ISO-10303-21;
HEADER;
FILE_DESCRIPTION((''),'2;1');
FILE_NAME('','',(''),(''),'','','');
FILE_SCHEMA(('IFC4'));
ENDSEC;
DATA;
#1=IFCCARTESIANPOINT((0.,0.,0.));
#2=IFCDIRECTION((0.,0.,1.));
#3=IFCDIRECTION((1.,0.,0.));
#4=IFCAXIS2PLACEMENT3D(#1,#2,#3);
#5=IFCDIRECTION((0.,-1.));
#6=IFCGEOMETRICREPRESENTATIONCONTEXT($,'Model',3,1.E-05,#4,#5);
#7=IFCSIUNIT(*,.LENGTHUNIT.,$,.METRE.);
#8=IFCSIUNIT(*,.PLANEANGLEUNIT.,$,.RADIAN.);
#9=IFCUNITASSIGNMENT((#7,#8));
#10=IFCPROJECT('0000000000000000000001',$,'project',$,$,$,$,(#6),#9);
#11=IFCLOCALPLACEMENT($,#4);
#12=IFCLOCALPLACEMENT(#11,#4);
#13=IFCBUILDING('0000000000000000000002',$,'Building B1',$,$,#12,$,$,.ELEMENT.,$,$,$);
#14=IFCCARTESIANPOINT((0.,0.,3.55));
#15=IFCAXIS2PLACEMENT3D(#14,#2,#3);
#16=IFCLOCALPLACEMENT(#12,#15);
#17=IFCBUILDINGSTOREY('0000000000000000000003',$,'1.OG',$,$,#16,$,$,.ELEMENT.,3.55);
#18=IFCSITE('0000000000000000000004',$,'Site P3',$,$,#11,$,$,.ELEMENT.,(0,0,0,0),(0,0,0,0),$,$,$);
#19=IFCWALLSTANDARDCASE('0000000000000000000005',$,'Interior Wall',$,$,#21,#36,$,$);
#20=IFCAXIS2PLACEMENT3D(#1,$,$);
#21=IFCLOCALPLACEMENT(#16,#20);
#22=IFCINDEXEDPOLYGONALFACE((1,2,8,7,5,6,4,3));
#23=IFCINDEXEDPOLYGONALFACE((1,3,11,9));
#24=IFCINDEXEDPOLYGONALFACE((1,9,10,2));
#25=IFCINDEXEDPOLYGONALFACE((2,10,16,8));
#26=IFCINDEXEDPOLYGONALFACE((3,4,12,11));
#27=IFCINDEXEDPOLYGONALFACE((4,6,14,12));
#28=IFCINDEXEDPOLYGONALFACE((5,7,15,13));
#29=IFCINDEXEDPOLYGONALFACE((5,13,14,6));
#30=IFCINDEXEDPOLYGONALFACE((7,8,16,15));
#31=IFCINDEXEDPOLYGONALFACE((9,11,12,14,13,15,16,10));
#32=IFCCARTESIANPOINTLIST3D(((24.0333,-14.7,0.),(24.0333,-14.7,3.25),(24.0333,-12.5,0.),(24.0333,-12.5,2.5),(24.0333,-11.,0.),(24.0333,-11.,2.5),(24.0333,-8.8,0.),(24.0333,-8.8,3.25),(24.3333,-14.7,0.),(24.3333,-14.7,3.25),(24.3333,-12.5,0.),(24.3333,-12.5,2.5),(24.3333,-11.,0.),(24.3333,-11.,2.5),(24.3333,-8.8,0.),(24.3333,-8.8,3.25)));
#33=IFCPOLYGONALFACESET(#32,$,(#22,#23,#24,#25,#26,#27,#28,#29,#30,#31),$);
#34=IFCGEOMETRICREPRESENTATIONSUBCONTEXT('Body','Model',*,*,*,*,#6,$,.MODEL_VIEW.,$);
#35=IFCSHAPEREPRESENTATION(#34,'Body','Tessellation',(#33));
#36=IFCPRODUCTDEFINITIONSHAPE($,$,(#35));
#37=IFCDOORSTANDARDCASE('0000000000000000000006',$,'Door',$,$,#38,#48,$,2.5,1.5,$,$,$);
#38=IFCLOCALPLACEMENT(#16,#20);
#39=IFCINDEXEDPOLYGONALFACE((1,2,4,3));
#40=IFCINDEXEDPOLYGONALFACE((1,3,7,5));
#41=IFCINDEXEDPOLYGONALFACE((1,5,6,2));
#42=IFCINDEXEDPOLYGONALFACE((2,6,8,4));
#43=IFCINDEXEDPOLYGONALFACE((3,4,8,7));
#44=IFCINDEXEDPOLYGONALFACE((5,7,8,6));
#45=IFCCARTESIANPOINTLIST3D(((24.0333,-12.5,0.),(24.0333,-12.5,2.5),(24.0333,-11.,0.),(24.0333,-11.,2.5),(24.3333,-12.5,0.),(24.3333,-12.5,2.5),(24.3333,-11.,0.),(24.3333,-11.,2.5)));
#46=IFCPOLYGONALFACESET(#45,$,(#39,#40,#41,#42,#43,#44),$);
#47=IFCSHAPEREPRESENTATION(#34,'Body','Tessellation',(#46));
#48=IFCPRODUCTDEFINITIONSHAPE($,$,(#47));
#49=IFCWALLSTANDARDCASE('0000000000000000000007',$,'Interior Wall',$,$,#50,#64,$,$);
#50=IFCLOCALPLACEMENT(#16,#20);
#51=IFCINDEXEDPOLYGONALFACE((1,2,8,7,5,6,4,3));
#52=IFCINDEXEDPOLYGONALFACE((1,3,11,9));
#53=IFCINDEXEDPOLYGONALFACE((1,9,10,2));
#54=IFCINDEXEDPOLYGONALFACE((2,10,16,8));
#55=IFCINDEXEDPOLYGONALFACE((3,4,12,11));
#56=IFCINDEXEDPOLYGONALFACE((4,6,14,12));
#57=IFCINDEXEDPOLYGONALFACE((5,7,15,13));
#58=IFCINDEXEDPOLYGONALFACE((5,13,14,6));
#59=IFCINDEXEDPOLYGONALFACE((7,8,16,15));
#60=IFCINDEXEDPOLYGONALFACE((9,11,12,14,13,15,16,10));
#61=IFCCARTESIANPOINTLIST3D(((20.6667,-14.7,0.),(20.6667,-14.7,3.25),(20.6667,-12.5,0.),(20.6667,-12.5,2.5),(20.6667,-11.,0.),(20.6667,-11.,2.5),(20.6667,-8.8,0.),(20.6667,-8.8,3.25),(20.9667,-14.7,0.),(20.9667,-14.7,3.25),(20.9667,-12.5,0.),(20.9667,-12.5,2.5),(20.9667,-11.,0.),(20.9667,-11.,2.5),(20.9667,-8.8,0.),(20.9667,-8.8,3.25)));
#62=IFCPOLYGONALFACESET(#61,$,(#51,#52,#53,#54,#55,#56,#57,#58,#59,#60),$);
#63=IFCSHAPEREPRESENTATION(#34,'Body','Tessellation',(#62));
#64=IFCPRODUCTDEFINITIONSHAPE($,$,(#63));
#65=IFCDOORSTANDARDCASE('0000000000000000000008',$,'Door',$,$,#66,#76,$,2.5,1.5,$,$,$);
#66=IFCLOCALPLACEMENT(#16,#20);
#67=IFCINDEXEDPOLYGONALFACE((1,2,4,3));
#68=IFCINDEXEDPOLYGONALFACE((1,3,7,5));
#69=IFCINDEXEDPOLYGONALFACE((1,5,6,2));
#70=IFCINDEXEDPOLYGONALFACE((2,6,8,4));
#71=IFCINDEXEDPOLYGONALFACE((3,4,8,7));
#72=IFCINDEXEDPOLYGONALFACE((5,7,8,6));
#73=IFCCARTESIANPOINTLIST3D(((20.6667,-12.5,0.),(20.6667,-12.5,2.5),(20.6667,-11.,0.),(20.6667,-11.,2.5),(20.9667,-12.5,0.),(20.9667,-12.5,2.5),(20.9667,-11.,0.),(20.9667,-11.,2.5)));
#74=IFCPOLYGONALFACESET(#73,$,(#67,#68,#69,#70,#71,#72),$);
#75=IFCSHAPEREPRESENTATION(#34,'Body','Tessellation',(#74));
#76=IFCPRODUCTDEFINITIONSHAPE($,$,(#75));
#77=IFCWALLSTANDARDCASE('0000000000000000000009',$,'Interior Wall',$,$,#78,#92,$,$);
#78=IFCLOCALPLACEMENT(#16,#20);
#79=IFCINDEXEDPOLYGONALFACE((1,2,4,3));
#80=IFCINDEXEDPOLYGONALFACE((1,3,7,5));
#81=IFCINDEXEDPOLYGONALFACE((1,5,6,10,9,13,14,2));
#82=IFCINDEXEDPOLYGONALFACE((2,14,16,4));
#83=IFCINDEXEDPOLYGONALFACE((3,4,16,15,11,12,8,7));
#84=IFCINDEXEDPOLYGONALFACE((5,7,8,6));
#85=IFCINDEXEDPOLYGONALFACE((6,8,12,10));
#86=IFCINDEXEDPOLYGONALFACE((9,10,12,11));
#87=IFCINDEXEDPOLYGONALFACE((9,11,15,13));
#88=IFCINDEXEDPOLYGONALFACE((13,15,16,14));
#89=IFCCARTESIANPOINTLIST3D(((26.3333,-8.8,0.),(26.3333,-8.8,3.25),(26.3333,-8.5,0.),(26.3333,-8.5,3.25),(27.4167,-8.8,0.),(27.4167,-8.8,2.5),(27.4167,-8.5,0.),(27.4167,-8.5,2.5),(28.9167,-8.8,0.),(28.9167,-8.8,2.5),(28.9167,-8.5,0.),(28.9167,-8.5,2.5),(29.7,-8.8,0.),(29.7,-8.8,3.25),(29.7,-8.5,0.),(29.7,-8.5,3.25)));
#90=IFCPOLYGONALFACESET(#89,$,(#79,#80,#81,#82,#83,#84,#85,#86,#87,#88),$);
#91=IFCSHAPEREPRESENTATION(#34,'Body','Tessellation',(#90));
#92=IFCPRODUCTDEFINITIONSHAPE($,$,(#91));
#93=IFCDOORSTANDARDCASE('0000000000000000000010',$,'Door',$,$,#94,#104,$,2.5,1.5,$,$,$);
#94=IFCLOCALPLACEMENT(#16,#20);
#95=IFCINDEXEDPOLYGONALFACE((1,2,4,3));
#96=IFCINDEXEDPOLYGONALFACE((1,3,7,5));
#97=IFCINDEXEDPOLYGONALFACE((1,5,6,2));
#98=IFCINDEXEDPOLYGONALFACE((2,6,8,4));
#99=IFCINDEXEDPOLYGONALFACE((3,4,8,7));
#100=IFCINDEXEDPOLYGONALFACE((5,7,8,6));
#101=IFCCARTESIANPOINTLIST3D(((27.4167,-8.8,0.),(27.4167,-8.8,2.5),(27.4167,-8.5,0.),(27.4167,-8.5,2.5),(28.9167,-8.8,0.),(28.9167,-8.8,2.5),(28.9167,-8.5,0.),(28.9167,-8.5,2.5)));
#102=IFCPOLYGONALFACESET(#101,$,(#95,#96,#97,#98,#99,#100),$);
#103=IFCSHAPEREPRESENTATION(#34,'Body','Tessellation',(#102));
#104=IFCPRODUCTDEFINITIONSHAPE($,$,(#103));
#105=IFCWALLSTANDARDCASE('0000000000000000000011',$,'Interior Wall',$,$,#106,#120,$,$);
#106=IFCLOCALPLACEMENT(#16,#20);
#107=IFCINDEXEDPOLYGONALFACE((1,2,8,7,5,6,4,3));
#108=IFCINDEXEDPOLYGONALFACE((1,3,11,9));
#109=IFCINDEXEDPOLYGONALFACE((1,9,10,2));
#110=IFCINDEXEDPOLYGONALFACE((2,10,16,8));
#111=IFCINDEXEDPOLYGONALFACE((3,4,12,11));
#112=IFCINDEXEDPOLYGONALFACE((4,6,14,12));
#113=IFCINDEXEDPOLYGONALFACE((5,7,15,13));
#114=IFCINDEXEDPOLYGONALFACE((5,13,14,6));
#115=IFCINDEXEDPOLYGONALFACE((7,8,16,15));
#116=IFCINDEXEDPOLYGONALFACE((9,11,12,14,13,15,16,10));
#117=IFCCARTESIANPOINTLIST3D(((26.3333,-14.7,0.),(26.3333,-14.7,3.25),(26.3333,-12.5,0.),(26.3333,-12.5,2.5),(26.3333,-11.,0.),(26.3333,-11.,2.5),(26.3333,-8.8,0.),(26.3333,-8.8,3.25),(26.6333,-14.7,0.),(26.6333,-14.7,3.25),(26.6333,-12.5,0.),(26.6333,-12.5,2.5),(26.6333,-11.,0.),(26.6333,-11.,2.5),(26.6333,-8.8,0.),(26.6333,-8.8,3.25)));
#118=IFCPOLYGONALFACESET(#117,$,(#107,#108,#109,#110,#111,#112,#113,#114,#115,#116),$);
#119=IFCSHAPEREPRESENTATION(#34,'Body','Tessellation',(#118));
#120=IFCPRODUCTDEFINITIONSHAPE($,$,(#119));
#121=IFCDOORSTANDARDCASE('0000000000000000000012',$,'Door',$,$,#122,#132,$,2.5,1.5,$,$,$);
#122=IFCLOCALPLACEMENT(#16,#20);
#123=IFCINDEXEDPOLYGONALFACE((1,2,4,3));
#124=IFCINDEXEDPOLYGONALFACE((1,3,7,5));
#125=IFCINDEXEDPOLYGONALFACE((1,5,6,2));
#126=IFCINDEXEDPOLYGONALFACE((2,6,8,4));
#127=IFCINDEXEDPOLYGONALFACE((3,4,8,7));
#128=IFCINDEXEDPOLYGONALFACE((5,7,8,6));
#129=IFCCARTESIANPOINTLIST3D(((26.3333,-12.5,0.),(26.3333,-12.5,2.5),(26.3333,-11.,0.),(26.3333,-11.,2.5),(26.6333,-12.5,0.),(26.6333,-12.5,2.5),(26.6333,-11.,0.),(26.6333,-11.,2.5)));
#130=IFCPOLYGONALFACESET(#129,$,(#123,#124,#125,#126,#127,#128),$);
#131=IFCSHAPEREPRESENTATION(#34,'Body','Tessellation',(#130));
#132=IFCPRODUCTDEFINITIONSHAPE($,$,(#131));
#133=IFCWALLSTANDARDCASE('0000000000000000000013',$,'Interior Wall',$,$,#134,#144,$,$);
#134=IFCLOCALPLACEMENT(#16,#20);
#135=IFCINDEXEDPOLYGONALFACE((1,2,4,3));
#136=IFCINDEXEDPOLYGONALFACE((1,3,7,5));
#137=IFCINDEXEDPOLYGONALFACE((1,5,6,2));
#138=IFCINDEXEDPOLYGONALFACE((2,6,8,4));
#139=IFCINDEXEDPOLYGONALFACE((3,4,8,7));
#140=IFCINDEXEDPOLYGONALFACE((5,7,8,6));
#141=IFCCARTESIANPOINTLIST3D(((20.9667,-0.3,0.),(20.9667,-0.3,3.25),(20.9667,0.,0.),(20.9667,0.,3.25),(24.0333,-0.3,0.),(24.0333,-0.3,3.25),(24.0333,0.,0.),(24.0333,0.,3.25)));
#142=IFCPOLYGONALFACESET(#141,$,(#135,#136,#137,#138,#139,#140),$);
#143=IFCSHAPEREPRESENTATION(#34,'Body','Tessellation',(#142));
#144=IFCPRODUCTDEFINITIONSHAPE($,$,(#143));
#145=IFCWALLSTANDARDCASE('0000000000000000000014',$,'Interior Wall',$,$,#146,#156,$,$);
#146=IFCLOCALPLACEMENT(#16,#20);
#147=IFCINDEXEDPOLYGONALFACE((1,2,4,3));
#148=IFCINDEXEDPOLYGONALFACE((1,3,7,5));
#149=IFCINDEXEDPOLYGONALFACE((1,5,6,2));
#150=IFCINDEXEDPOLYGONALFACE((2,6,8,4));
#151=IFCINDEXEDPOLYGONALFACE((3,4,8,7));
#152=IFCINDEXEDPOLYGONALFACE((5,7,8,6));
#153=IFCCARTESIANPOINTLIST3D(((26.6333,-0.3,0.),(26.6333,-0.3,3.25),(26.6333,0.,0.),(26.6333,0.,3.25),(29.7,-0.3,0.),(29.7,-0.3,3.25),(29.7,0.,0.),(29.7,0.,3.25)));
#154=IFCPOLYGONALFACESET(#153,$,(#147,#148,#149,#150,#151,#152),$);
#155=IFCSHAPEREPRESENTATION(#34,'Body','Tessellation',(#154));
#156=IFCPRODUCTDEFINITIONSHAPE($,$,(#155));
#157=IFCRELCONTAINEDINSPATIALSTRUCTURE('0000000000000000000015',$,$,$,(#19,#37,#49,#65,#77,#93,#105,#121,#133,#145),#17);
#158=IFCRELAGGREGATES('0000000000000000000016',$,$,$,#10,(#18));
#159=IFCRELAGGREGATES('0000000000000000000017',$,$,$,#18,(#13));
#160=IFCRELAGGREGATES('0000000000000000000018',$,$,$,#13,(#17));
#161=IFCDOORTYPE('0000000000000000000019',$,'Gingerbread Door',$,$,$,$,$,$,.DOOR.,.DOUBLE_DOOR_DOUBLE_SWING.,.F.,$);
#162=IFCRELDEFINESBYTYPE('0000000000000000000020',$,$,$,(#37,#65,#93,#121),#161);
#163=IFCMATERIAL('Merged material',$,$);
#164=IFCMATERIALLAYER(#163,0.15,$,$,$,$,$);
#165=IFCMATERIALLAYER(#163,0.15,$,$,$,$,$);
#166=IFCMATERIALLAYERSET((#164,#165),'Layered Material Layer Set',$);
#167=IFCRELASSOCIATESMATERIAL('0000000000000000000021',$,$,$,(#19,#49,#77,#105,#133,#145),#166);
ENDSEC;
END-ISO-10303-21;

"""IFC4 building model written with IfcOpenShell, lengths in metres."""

from ifc_helpers import new_model, si_unit, direction, frame, origin_with_axes, place, context, subcontext, project, spatial, polyline, outline, extrude, source, transform, mapped, material, layer, layer_set, layer_usage, type_object, element, fill, save


model = new_model("IFC4")

# Units and contexts
model_context = context("Model", 3, precision=1e-05, world=origin_with_axes(), true_north=direction((0.0, -1.0)))
body_context = subcontext(model_context, "Body", "Model", "MODEL_VIEW")
ifc_project = project(units=[si_unit("LENGTHUNIT", "METRE"), si_unit("PLANEANGLEUNIT", "RADIAN")], contexts=[model_context])

# Site, building, storey
site_placement = place(None, origin_with_axes())
site = spatial("IfcSite", under=ifc_project, at=site_placement, Name="Site P3", CompositionType="ELEMENT", RefLatitude=(0, 0, 0, 0), RefLongitude=(0, 0, 0, 0))
building_placement = place(site_placement, origin_with_axes())
building = spatial("IfcBuilding", under=site, at=building_placement, Name="Building B1", CompositionType="ELEMENT")
storey_placement = place(building_placement, frame((0.0, 0.0, 3.55), z_axis=(0.0, 0.0, 1.0), x_axis=(1.0, 0.0, 0.0)))
storey = spatial("IfcBuildingStorey", under=building, at=storey_placement, Name="1.OG", CompositionType="ELEMENT", Elevation=3.55)

# Shared definitions
ifc_material = material(Name="Merged material")

# Walls, openings, doors
ifc_layer_1 = layer(ifc_material, 0.15)
ifc_layer_2 = layer(ifc_material, 0.15)
ifc_layer_set_1 = layer_set([ifc_layer_1, ifc_layer_2], Name="Layered Material Layer Set")
ifc_layer_usage_1 = layer_usage(ifc_layer_set_1, "AXIS2", "POSITIVE", -0.15)
door_type = type_object("IfcDoorType", Name="Gingerbread Door", OperationType="DOUBLE_DOOR_DOUBLE_SWING", ParameterTakesPrecedence=False, PredefinedType="DOOR")
shared_shape_1 = source(origin_with_axes(), body_context, "Body", "SweptSolid", [
    extrude(outline(polyline([(0.0, 0.0), (0.0, 1.5), (2.5, 1.5), (2.5, 0.0), (0.0, 0.0)])), frame((0.0, -0.15, 0.0), z_axis=(0.0, 1.0, 0.0), x_axis=(0.0, 0.0, 1.0)), (0.0, 0.0, 1.0), 0.3),
])
wall_1_placement = place(storey_placement, frame((24.1833, -8.8, 0.0), z_axis=(0.0, 0.0, 1.0), x_axis=(0.0, -1.0, 0.0)))
wall_1 = element("IfcWallStandardCase", 1, at=wall_1_placement, inside=storey, material=ifc_layer_usage_1, Name="Interior Wall", context=body_context, shape_type="SweptSolid", body=[
    extrude(outline(polyline([(0.0, 0.15), (5.9, 0.15), (5.9, -0.15), (0.0, -0.15), (0.0, 0.15)])), origin_with_axes(), (0.0, 0.0, 1.0), 3.25),
])
opening_1_placement = place(wall_1_placement, frame((2.2, 0.0, 0.0), z_axis=(0.0, 0.0, 1.0), x_axis=(1.0, 0.0, 0.0)))
opening_1 = element("IfcOpeningStandardCase", 2, at=opening_1_placement, cuts=wall_1, context=body_context, shape_type="SweptSolid", body=[
    extrude(outline(polyline([(0.0, 0.0), (0.0, 1.5), (2.5, 1.5), (2.5, 0.0), (0.0, 0.0)])), frame((0.0, -0.15, 0.0), z_axis=(0.0, 1.0, 0.0), x_axis=(0.0, 0.0, 1.0)), (0.0, 0.0, 1.0), 0.3),
])
door_1_placement = place(opening_1_placement, origin_with_axes())
door_1 = element("IfcDoorStandardCase", 3, at=door_1_placement, inside=storey, type_object=door_type, Name="Door", OverallHeight=2.5, OverallWidth=1.5, context=body_context, shape_type="MappedRepresentation", body=[
    mapped(shared_shape_1, transform((0.0, 0.0, 0.0))),
])
fill(opening_1, door_1)
wall_2_placement = place(storey_placement, frame((20.8167, -8.8, 0.0), z_axis=(0.0, 0.0, 1.0), x_axis=(0.0, -1.0, 0.0)))
wall_2 = element("IfcWallStandardCase", 4, at=wall_2_placement, inside=storey, material=ifc_layer_usage_1, Name="Interior Wall", context=body_context, shape_type="SweptSolid", body=[
    extrude(outline(polyline([(0.0, 0.15), (5.9, 0.15), (5.9, -0.15), (0.0, -0.15), (0.0, 0.15)])), origin_with_axes(), (0.0, 0.0, 1.0), 3.25),
])
opening_2_placement = place(wall_2_placement, frame((2.2, 0.0, 0.0), z_axis=(0.0, 0.0, 1.0), x_axis=(1.0, 0.0, 0.0)))
opening_2 = element("IfcOpeningStandardCase", 5, at=opening_2_placement, cuts=wall_2, context=body_context, shape_type="SweptSolid", body=[
    extrude(outline(polyline([(0.0, 0.0), (0.0, 1.5), (2.5, 1.5), (2.5, 0.0), (0.0, 0.0)])), frame((0.0, -0.15, 0.0), z_axis=(0.0, 1.0, 0.0), x_axis=(0.0, 0.0, 1.0)), (0.0, 0.0, 1.0), 0.3),
])
door_2_placement = place(opening_2_placement, origin_with_axes())
door_2 = element("IfcDoorStandardCase", 6, at=door_2_placement, inside=storey, type_object=door_type, Name="Door", OverallHeight=2.5, OverallWidth=1.5, context=body_context, shape_type="MappedRepresentation", body=[
    mapped(shared_shape_1, transform((0.0, 0.0, 0.0))),
])
fill(opening_2, door_2)
wall_3_placement = place(storey_placement, frame((26.3333, -8.65, 0.0), z_axis=(0.0, 0.0, 1.0), x_axis=(1.0, 0.0, 0.0)))
wall_3 = element("IfcWallStandardCase", 7, at=wall_3_placement, inside=storey, material=ifc_layer_usage_1, Name="Interior Wall", context=body_context, shape_type="SweptSolid", body=[
    extrude(outline(polyline([(0.0, 0.15), (3.3667, 0.15), (3.3667, -0.15), (0.0, -0.15), (0.0, 0.15)])), origin_with_axes(), (0.0, 0.0, 1.0), 3.25),
])
opening_3_placement = place(wall_3_placement, frame((1.0833, 0.0, 0.0), z_axis=(0.0, 0.0, 1.0), x_axis=(1.0, 0.0, 0.0)))
opening_3 = element("IfcOpeningStandardCase", 8, at=opening_3_placement, cuts=wall_3, context=body_context, shape_type="SweptSolid", body=[
    extrude(outline(polyline([(0.0, 0.0), (0.0, 1.5), (2.5, 1.5), (2.5, 0.0), (0.0, 0.0)])), frame((0.0, -0.15, 0.0), z_axis=(0.0, 1.0, 0.0), x_axis=(0.0, 0.0, 1.0)), (0.0, 0.0, 1.0), 0.3),
])
door_3_placement = place(opening_3_placement, origin_with_axes())
door_3 = element("IfcDoorStandardCase", 9, at=door_3_placement, inside=storey, type_object=door_type, Name="Door", OverallHeight=2.5, OverallWidth=1.5, context=body_context, shape_type="MappedRepresentation", body=[
    mapped(shared_shape_1, transform((0.0, 0.0, 0.0))),
])
fill(opening_3, door_3)
wall_4_placement = place(storey_placement, frame((26.4833, -8.8, 0.0), z_axis=(0.0, 0.0, 1.0), x_axis=(0.0, -1.0, 0.0)))
wall_4 = element("IfcWallStandardCase", 10, at=wall_4_placement, inside=storey, material=ifc_layer_usage_1, Name="Interior Wall", context=body_context, shape_type="SweptSolid", body=[
    extrude(outline(polyline([(0.0, 0.15), (5.9, 0.15), (5.9, -0.15), (0.0, -0.15), (0.0, 0.15)])), origin_with_axes(), (0.0, 0.0, 1.0), 3.25),
])
opening_4_placement = place(wall_4_placement, frame((2.2, 0.0, 0.0), z_axis=(0.0, 0.0, 1.0), x_axis=(1.0, 0.0, 0.0)))
opening_4 = element("IfcOpeningStandardCase", 11, at=opening_4_placement, cuts=wall_4, context=body_context, shape_type="SweptSolid", body=[
    extrude(outline(polyline([(0.0, 0.0), (0.0, 1.5), (2.5, 1.5), (2.5, 0.0), (0.0, 0.0)])), frame((0.0, -0.15, 0.0), z_axis=(0.0, 1.0, 0.0), x_axis=(0.0, 0.0, 1.0)), (0.0, 0.0, 1.0), 0.3),
])
door_4_placement = place(opening_4_placement, origin_with_axes())
door_4 = element("IfcDoorStandardCase", 12, at=door_4_placement, inside=storey, type_object=door_type, Name="Door", OverallHeight=2.5, OverallWidth=1.5, context=body_context, shape_type="MappedRepresentation", body=[
    mapped(shared_shape_1, transform((0.0, 0.0, 0.0))),
])
fill(opening_4, door_4)

# Walls
wall_5_placement = place(storey_placement, frame((20.9667, -0.15, 0.0), z_axis=(0.0, 0.0, 1.0), x_axis=(1.0, 0.0, 0.0)))
element("IfcWallStandardCase", 13, at=wall_5_placement, inside=storey, material=ifc_layer_usage_1, Name="Interior Wall", context=body_context, shape_type="SweptSolid", body=[
    extrude(outline(polyline([(0.0, 0.15), (3.0667, 0.15), (3.0667, -0.15), (0.0, -0.15), (0.0, 0.15)])), origin_with_axes(), (0.0, 0.0, 1.0), 3.25),
])
wall_6_placement = place(storey_placement, frame((26.6333, -0.15, 0.0), z_axis=(0.0, 0.0, 1.0), x_axis=(1.0, 0.0, 0.0)))
element("IfcWallStandardCase", 14, at=wall_6_placement, inside=storey, material=ifc_layer_usage_1, Name="Interior Wall", context=body_context, shape_type="SweptSolid", body=[
    extrude(outline(polyline([(0.0, 0.15), (3.0667, 0.15), (3.0667, -0.15), (0.0, -0.15), (0.0, 0.15)])), origin_with_axes(), (0.0, 0.0, 1.0), 3.25),
])

save(model, "model.ifc")
